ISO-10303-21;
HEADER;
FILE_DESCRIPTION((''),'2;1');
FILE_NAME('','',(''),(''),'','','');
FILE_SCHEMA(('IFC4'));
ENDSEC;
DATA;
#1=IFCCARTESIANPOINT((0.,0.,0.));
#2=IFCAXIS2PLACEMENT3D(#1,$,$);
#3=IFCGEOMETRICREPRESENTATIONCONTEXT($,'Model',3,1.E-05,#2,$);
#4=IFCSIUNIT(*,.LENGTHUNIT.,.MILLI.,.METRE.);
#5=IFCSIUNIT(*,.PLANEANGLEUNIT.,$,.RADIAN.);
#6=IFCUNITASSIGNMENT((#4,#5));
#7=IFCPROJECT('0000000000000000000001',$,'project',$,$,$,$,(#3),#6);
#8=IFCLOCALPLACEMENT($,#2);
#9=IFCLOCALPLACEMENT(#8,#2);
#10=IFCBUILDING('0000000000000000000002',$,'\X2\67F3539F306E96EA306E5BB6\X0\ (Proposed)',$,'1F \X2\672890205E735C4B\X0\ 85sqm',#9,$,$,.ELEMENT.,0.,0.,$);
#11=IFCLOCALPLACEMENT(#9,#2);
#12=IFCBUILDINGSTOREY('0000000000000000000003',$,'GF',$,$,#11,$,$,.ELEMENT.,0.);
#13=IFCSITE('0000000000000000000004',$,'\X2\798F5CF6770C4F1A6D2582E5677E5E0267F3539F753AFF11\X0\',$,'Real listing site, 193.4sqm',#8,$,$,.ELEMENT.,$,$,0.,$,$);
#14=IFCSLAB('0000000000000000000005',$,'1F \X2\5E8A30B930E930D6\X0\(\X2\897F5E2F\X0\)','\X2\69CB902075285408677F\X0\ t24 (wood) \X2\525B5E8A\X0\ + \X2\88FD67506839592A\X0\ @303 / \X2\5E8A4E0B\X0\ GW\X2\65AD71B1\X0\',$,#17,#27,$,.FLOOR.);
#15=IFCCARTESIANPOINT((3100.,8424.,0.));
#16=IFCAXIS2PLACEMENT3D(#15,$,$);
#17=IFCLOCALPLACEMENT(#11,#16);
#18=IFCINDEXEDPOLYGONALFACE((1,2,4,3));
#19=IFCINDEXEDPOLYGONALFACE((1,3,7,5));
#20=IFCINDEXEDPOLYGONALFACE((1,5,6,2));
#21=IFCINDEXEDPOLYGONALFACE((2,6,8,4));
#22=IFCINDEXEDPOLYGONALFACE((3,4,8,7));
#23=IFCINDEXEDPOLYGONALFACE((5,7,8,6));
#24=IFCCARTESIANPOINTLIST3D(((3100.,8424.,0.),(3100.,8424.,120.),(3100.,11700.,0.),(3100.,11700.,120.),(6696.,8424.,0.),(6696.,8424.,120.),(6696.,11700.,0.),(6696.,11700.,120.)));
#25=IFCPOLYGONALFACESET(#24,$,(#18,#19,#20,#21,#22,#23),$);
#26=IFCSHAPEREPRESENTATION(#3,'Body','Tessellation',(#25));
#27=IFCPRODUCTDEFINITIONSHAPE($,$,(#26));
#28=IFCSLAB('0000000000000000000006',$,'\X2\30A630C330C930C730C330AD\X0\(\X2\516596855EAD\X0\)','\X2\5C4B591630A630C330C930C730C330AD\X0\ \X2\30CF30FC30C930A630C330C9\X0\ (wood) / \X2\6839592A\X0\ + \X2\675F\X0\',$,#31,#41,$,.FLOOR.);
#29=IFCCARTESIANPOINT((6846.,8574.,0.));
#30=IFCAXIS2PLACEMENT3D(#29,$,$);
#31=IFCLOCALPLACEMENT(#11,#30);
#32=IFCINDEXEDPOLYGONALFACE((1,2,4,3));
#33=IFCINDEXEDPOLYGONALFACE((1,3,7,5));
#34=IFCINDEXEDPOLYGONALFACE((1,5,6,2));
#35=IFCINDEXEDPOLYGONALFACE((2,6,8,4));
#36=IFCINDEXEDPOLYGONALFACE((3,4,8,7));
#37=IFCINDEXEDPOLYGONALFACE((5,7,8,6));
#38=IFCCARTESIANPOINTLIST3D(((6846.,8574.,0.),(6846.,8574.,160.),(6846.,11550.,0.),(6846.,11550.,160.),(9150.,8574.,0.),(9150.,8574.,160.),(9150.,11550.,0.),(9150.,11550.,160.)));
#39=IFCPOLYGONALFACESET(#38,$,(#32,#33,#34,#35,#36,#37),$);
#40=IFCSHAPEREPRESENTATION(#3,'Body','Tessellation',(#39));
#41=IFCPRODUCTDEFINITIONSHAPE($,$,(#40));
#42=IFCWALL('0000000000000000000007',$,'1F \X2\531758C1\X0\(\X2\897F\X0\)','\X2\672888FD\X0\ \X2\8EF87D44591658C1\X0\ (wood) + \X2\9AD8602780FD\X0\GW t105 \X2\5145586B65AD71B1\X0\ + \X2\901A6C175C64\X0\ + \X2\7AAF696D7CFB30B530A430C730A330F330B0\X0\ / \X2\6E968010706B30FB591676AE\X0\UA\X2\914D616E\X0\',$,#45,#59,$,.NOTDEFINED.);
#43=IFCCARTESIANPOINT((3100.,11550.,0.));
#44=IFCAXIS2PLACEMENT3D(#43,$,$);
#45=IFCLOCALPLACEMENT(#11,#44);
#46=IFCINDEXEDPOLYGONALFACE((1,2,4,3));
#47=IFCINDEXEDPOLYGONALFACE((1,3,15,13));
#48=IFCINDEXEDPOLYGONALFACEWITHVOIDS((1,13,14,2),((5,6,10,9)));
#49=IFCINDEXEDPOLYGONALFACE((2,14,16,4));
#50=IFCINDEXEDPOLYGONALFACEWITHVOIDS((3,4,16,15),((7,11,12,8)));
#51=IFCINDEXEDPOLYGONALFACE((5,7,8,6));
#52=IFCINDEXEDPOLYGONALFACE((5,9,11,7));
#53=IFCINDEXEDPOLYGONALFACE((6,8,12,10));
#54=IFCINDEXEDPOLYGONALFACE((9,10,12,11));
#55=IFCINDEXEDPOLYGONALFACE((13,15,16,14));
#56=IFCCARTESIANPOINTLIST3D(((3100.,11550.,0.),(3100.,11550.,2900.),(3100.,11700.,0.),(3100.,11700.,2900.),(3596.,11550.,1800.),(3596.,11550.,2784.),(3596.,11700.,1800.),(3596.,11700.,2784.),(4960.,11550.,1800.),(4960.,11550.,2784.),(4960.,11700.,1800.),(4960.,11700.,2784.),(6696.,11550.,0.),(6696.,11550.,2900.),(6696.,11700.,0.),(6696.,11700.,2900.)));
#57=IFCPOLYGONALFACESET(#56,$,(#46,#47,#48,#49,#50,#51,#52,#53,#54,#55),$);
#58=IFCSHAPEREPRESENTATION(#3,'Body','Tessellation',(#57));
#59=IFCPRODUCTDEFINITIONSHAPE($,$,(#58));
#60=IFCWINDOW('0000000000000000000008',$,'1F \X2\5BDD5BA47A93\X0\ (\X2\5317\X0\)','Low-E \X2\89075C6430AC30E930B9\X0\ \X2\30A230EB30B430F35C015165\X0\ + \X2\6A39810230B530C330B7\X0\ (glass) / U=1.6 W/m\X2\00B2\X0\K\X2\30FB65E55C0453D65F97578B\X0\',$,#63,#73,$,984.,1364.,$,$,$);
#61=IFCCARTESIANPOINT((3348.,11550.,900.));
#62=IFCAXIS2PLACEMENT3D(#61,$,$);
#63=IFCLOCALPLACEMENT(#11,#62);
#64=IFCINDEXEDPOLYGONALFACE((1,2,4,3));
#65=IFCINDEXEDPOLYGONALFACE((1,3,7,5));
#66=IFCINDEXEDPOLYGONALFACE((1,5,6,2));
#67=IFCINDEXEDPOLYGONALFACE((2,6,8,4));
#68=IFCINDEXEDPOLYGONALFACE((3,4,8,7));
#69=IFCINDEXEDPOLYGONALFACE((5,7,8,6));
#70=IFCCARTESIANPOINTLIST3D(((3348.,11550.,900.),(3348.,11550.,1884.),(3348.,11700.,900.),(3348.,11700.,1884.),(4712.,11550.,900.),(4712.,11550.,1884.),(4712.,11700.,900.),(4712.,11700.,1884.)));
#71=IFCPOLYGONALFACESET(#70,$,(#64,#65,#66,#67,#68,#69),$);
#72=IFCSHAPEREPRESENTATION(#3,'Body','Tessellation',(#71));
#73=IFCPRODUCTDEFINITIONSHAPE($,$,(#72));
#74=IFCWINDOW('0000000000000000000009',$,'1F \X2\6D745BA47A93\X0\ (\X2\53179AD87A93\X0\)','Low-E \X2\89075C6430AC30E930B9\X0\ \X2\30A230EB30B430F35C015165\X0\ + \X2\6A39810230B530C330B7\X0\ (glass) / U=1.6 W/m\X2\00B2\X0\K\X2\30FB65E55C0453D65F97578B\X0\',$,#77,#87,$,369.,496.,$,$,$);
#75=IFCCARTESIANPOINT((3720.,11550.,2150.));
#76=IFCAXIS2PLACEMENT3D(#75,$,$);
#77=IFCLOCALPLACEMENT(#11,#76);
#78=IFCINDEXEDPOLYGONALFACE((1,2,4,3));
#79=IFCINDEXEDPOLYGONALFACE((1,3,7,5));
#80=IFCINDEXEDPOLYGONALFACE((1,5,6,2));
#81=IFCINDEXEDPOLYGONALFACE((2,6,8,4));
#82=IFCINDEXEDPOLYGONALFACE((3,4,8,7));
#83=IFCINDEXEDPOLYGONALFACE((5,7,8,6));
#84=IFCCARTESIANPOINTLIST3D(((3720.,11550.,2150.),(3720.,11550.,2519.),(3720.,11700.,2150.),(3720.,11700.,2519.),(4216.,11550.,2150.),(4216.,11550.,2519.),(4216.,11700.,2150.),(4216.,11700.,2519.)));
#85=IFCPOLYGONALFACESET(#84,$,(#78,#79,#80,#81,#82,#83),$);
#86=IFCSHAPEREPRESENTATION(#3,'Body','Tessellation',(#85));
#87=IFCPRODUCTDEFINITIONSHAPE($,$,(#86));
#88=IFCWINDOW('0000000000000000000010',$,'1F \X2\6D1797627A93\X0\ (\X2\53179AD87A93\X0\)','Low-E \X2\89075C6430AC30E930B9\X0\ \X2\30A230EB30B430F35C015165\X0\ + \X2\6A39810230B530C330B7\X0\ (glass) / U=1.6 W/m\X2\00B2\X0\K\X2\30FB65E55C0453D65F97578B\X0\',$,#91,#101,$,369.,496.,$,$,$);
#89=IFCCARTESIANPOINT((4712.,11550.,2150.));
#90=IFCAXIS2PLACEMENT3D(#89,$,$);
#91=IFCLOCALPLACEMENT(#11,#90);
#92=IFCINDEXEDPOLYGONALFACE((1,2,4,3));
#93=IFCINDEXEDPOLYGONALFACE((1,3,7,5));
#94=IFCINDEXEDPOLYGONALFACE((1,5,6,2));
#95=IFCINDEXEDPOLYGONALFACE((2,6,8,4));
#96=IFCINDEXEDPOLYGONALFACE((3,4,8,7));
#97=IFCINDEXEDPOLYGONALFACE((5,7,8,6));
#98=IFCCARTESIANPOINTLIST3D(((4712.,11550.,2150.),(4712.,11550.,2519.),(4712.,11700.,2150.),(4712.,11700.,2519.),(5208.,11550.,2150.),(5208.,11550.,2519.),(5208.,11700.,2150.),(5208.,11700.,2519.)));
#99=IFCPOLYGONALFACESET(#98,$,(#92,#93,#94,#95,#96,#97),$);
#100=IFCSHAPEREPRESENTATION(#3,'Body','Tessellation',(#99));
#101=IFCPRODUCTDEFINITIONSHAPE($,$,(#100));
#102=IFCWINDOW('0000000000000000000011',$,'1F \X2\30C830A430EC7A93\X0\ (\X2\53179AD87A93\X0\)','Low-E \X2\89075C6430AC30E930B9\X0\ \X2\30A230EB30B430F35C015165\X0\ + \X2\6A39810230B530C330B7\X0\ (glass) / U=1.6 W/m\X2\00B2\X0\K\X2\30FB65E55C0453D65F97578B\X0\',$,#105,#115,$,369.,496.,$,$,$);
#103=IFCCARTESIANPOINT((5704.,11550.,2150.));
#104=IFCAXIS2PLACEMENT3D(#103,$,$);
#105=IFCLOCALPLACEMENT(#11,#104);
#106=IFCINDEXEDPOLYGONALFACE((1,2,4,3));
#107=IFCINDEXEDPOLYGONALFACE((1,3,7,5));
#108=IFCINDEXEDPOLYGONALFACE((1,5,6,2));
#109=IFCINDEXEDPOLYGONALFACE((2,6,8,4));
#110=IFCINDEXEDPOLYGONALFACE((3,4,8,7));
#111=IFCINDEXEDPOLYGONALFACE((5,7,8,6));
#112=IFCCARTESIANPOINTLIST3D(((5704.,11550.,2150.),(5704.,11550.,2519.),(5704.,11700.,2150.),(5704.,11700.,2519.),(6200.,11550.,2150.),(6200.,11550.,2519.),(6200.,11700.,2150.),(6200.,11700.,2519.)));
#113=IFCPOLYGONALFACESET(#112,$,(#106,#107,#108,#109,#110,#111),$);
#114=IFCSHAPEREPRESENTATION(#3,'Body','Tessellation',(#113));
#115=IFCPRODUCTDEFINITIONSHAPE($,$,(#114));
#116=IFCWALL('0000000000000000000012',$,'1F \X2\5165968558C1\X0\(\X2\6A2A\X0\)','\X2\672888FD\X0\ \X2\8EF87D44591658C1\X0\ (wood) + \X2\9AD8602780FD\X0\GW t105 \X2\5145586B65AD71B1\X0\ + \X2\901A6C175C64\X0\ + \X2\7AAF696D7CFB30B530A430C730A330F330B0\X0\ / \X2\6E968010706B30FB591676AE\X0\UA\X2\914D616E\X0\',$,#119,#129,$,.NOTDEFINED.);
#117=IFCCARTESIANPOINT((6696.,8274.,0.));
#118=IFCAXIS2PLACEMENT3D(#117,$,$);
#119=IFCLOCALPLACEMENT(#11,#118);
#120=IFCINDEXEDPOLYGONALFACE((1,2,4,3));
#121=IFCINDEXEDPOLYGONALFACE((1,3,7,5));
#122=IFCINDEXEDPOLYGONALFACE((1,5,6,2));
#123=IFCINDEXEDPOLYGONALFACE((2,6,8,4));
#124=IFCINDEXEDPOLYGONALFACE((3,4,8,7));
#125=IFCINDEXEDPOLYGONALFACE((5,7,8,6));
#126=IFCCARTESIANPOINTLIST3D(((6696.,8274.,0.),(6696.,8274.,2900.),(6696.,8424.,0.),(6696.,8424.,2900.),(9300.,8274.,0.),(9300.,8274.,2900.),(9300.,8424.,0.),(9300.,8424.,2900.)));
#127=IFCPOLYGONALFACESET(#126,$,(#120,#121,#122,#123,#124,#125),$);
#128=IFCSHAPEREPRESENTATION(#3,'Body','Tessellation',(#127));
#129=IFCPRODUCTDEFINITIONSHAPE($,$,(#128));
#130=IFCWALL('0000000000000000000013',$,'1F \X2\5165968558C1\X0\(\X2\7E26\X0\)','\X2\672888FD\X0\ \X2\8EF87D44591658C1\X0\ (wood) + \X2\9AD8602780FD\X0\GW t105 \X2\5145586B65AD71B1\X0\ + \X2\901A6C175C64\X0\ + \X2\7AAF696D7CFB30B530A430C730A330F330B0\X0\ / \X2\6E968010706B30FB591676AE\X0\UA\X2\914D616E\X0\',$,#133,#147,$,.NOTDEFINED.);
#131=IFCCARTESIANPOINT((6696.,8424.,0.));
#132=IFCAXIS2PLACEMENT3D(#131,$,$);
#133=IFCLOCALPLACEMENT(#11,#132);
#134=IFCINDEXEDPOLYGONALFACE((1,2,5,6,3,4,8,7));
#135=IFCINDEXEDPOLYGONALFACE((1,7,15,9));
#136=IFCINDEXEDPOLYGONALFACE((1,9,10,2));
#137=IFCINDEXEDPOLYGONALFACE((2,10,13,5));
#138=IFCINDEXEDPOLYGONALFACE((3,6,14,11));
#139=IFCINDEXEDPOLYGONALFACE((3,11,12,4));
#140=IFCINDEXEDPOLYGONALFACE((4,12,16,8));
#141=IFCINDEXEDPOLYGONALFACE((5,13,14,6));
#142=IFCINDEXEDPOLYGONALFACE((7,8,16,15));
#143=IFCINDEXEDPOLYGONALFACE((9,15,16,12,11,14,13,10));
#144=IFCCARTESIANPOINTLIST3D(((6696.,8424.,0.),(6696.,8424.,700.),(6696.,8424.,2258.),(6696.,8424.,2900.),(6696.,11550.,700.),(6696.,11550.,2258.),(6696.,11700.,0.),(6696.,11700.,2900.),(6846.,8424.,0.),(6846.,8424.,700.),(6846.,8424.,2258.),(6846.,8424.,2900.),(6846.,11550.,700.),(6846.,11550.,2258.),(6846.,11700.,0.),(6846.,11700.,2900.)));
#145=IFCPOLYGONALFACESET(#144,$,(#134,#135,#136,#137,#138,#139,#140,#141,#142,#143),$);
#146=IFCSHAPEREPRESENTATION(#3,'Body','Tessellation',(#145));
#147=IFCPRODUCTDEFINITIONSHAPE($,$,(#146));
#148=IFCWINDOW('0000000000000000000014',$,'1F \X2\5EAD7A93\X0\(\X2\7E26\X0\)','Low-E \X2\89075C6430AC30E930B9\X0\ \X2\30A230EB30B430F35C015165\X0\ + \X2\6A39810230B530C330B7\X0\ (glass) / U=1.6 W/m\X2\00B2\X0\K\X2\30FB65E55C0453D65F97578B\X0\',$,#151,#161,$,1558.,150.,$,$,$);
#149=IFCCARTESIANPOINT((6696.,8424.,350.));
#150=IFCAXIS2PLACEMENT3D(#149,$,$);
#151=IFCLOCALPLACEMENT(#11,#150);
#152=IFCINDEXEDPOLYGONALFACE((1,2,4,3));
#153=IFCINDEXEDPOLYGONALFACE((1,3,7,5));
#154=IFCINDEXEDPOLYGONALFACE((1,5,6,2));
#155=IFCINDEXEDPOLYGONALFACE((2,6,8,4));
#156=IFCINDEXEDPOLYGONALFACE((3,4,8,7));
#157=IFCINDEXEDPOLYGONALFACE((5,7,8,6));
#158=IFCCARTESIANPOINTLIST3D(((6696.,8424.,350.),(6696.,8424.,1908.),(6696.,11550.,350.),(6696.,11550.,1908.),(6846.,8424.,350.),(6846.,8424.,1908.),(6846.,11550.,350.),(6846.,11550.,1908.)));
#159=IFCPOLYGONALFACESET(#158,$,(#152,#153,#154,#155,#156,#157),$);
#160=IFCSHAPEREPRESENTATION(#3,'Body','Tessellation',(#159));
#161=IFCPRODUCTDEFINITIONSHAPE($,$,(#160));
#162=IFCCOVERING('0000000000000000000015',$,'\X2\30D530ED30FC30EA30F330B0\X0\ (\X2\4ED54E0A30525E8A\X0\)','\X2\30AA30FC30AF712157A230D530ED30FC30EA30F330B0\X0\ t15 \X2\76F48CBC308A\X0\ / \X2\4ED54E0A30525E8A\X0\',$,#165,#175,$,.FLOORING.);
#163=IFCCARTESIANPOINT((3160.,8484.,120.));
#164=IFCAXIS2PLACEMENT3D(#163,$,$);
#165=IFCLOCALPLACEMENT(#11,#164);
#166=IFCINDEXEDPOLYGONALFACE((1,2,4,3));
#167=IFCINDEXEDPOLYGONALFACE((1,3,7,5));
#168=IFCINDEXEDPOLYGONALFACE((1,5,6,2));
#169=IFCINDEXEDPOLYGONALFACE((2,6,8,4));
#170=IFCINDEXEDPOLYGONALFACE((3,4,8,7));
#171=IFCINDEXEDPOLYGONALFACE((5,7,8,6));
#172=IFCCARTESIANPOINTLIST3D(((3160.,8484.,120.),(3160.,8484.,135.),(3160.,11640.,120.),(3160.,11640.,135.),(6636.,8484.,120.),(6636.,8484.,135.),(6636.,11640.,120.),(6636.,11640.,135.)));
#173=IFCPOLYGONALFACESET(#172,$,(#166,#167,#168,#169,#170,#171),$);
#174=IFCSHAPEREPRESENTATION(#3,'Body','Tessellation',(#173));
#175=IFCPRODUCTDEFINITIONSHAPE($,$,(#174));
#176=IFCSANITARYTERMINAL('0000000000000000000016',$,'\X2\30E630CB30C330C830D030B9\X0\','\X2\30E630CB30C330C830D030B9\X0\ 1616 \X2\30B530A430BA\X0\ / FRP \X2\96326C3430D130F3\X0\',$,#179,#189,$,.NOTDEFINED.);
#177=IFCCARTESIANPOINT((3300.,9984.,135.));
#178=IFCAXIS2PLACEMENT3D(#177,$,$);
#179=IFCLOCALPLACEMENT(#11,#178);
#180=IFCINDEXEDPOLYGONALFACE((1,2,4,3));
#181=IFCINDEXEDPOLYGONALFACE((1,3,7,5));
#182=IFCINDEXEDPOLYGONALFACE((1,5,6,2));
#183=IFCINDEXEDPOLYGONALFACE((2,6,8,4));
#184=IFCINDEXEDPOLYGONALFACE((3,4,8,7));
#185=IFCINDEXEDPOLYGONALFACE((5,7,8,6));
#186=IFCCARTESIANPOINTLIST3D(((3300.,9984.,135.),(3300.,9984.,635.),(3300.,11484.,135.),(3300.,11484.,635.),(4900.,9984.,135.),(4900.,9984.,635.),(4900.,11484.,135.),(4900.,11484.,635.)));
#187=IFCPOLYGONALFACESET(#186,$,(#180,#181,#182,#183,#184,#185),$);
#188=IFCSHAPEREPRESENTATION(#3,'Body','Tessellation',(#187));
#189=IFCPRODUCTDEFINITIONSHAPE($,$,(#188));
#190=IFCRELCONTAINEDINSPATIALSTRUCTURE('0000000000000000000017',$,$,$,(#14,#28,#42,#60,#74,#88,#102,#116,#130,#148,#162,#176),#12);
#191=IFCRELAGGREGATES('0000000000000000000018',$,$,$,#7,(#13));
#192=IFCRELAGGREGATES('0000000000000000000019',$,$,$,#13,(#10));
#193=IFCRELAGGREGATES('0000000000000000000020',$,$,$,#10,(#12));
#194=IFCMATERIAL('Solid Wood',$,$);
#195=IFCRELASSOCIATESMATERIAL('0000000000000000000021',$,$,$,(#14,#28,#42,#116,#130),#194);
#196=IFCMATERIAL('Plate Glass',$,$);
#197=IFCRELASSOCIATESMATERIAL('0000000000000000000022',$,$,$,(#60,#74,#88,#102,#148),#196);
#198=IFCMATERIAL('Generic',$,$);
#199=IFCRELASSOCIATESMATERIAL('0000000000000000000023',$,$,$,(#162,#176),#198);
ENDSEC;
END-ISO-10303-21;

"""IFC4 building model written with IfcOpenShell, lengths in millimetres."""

from ifc_helpers import new_model, si_unit, frame, frame_2d, origin, place, context, project, spatial, rectangle, extrude, material, element, fill, save


model = new_model("IFC4")

# Units and contexts
model_context = context("Model", 3, precision=1e-05, world=origin())
ifc_project = project(units=[si_unit("LENGTHUNIT", "METRE", prefix="MILLI"), si_unit("PLANEANGLEUNIT", "RADIAN")], contexts=[model_context])

# Site, building, storey
site_placement = place(None, origin())
site = spatial("IfcSite", under=ifc_project, at=site_placement, Name="福島県会津若松市柳原町１", ObjectType="Real listing site, 193.4sqm", CompositionType="ELEMENT", RefElevation=0.0)
building_placement = place(site_placement, origin())
building = spatial("IfcBuilding", under=site, at=building_placement, Name="柳原の雪の家 (Proposed)", ObjectType="1F 木造平屋 85sqm", CompositionType="ELEMENT", ElevationOfRefHeight=0.0, ElevationOfTerrain=0.0)
storey_placement = place(building_placement, origin())
storey = spatial("IfcBuildingStorey", under=building, at=storey_placement, Name="GF", CompositionType="ELEMENT", Elevation=0.0)

# Slabs
ifc_material_1 = material(Name="Solid Wood")
slab_1_placement = place(storey_placement, frame((3100.0, 8424.0, 0.0)))
element("IfcSlab", 1, at=slab_1_placement, inside=storey, material=ifc_material_1, Name="1F 床スラブ(西帯)", Description="構造用合板 t24 (wood) 剛床 + 製材根太 @303 / 床下 GW断熱", PredefinedType="FLOOR", context=model_context, shape_type="SweptSolid", body=[
    extrude(rectangle(XDim=3596.0, YDim=3276.0, at=frame_2d((1798.0, 1638.0))), frame((3100.0, 8424.0, 0.0)), (0.0, 0.0, 1.0), 120.0),
])
slab_2_placement = place(storey_placement, frame((6846.0, 8574.0, 0.0)))
element("IfcSlab", 2, at=slab_2_placement, inside=storey, material=ifc_material_1, Name="ウッドデッキ(入隅庭)", Description="屋外ウッドデッキ ハードウッド (wood) / 根太 + 束", PredefinedType="FLOOR", context=model_context, shape_type="SweptSolid", body=[
    extrude(rectangle(XDim=2304.0, YDim=2976.0, at=frame_2d((1152.0, 1488.0))), frame((6846.0, 8574.0, 0.0)), (0.0, 0.0, 1.0), 160.0),
])

# Wall, openings, windows
wall_1_placement = place(storey_placement, frame((3100.0, 11550.0, 0.0)))
wall_1 = element("IfcWall", 3, at=wall_1_placement, inside=storey, material=ifc_material_1, Name="1F 北壁(西)", Description="木製 軸組外壁 (wood) + 高性能GW t105 充填断熱 + 通気層 + 窯業系サイディング / 準耐火・外皮UA配慮", PredefinedType="NOTDEFINED", context=model_context, shape_type="SweptSolid", body=[
    extrude(rectangle(XDim=3596.0, YDim=150.0, at=frame_2d((1798.0, 75.0))), frame((3100.0, 11550.0, 0.0)), (0.0, 0.0, 1.0), 2900.0),
])
opening_1_placement = place(storey_placement, frame((3348.0, 11550.0, 900.0)))
opening_1 = element("IfcOpeningElement", 4, at=opening_1_placement, cuts=wall_1, PredefinedType="NOTDEFINED", context=model_context, shape_type="SweptSolid", body=[
    extrude(rectangle(XDim=1364.0, YDim=150.0, at=frame_2d((682.0, 75.0))), frame((3348.0, 11550.0, 900.0)), (0.0, 0.0, 1.0), 984.0),
])
opening_2_placement = place(storey_placement, frame((3720.0, 11550.0, 2150.0)))
opening_2 = element("IfcOpeningElement", 5, at=opening_2_placement, cuts=wall_1, PredefinedType="NOTDEFINED", context=model_context, shape_type="SweptSolid", body=[
    extrude(rectangle(XDim=496.0, YDim=150.0, at=frame_2d((248.0, 75.0))), frame((3720.0, 11550.0, 2150.0)), (0.0, 0.0, 1.0), 369.0),
])
opening_3_placement = place(storey_placement, frame((4712.0, 11550.0, 2150.0)))
opening_3 = element("IfcOpeningElement", 6, at=opening_3_placement, cuts=wall_1, PredefinedType="NOTDEFINED", context=model_context, shape_type="SweptSolid", body=[
    extrude(rectangle(XDim=496.0, YDim=150.0, at=frame_2d((248.0, 75.0))), frame((4712.0, 11550.0, 2150.0)), (0.0, 0.0, 1.0), 369.0),
])
opening_4_placement = place(storey_placement, frame((5704.0, 11550.0, 2150.0)))
opening_4 = element("IfcOpeningElement", 7, at=opening_4_placement, cuts=wall_1, PredefinedType="NOTDEFINED", context=model_context, shape_type="SweptSolid", body=[
    extrude(rectangle(XDim=496.0, YDim=150.0, at=frame_2d((248.0, 75.0))), frame((5704.0, 11550.0, 2150.0)), (0.0, 0.0, 1.0), 369.0),
])
ifc_material_2 = material(Name="Plate Glass")
window_1_placement = place(storey_placement, frame((3348.0, 11550.0, 900.0)))
window_1 = element("IfcWindow", 8, at=window_1_placement, inside=storey, material=ifc_material_2, Name="1F 寝室窓 (北)", Description="Low-E 複層ガラス アルゴン封入 + 樹脂サッシ (glass) / U=1.6 W/m²K・日射取得型", OverallHeight=984.0, OverallWidth=1364.0, context=model_context, shape_type="SweptSolid", body=[
    extrude(rectangle(XDim=1364.0, YDim=150.0, at=frame_2d((682.0, 75.0))), frame((3348.0, 11550.0, 900.0)), (0.0, 0.0, 1.0), 984.0),
])
fill(opening_1, window_1)
window_2_placement = place(storey_placement, frame((3720.0, 11550.0, 2150.0)))
window_2 = element("IfcWindow", 9, at=window_2_placement, inside=storey, material=ifc_material_2, Name="1F 浴室窓 (北高窓)", Description="Low-E 複層ガラス アルゴン封入 + 樹脂サッシ (glass) / U=1.6 W/m²K・日射取得型", OverallHeight=369.0, OverallWidth=496.0, context=model_context, shape_type="SweptSolid", body=[
    extrude(rectangle(XDim=496.0, YDim=150.0, at=frame_2d((248.0, 75.0))), frame((3720.0, 11550.0, 2150.0)), (0.0, 0.0, 1.0), 369.0),
])
fill(opening_2, window_2)
window_3_placement = place(storey_placement, frame((4712.0, 11550.0, 2150.0)))
window_3 = element("IfcWindow", 10, at=window_3_placement, inside=storey, material=ifc_material_2, Name="1F 洗面窓 (北高窓)", Description="Low-E 複層ガラス アルゴン封入 + 樹脂サッシ (glass) / U=1.6 W/m²K・日射取得型", OverallHeight=369.0, OverallWidth=496.0, context=model_context, shape_type="SweptSolid", body=[
    extrude(rectangle(XDim=496.0, YDim=150.0, at=frame_2d((248.0, 75.0))), frame((4712.0, 11550.0, 2150.0)), (0.0, 0.0, 1.0), 369.0),
])
fill(opening_3, window_3)
window_4_placement = place(storey_placement, frame((5704.0, 11550.0, 2150.0)))
window_4 = element("IfcWindow", 11, at=window_4_placement, inside=storey, material=ifc_material_2, Name="1F トイレ窓 (北高窓)", Description="Low-E 複層ガラス アルゴン封入 + 樹脂サッシ (glass) / U=1.6 W/m²K・日射取得型", OverallHeight=369.0, OverallWidth=496.0, context=model_context, shape_type="SweptSolid", body=[
    extrude(rectangle(XDim=496.0, YDim=150.0, at=frame_2d((248.0, 75.0))), frame((5704.0, 11550.0, 2150.0)), (0.0, 0.0, 1.0), 369.0),
])
fill(opening_4, window_4)

# Wall
wall_2_placement = place(storey_placement, frame((6696.0, 8274.0, 0.0)))
element("IfcWall", 12, at=wall_2_placement, inside=storey, material=ifc_material_1, Name="1F 入隅壁(横)", Description="木製 軸組外壁 (wood) + 高性能GW t105 充填断熱 + 通気層 + 窯業系サイディング / 準耐火・外皮UA配慮", PredefinedType="NOTDEFINED", context=model_context, shape_type="SweptSolid", body=[
    extrude(rectangle(XDim=2604.0, YDim=150.0, at=frame_2d((1302.0, 75.0))), frame((6696.0, 8274.0, 0.0)), (0.0, 0.0, 1.0), 2900.0),
])

# Wall, opening, window
wall_3_placement = place(storey_placement, frame((6696.0, 8424.0, 0.0)))
wall_3 = element("IfcWall", 13, at=wall_3_placement, inside=storey, material=ifc_material_1, Name="1F 入隅壁(縦)", Description="木製 軸組外壁 (wood) + 高性能GW t105 充填断熱 + 通気層 + 窯業系サイディング / 準耐火・外皮UA配慮", PredefinedType="NOTDEFINED", context=model_context, shape_type="SweptSolid", body=[
    extrude(rectangle(XDim=150.0, YDim=3276.0, at=frame_2d((75.0, 1638.0))), frame((6696.0, 8424.0, 0.0)), (0.0, 0.0, 1.0), 2900.0),
])
opening_5_placement = place(storey_placement, frame((6696.0, 8424.0, 350.0)))
opening_5 = element("IfcOpeningElement", 14, at=opening_5_placement, cuts=wall_3, PredefinedType="NOTDEFINED", context=model_context, shape_type="SweptSolid", body=[
    extrude(rectangle(XDim=150.0, YDim=3126.0, at=frame_2d((75.0, 1563.0))), frame((6696.0, 8424.0, 350.0)), (0.0, 0.0, 1.0), 1558.0),
])
window_5_placement = place(storey_placement, frame((6696.0, 8424.0, 350.0)))
window_5 = element("IfcWindow", 15, at=window_5_placement, inside=storey, material=ifc_material_2, Name="1F 庭窓(縦)", Description="Low-E 複層ガラス アルゴン封入 + 樹脂サッシ (glass) / U=1.6 W/m²K・日射取得型", OverallHeight=1558.0, OverallWidth=150.0, context=model_context, shape_type="SweptSolid", body=[
    extrude(rectangle(XDim=150.0, YDim=3126.0, at=frame_2d((75.0, 1563.0))), frame((6696.0, 8424.0, 350.0)), (0.0, 0.0, 1.0), 1558.0),
])
fill(opening_5, window_5)

# Covering
ifc_material_3 = material(Name="Generic")
covering_placement = place(storey_placement, frame((3160.0, 8484.0, 120.0)))
element("IfcCovering", 16, at=covering_placement, inside=storey, material=ifc_material_3, Name="フローリング (仕上げ床)", Description="オーク無垢フローリング t15 直貼り / 仕上げ床", PredefinedType="FLOORING", context=model_context, shape_type="SweptSolid", body=[
    extrude(rectangle(XDim=3476.0, YDim=3156.0, at=frame_2d((1738.0, 1578.0))), frame((3160.0, 8484.0, 120.0)), (0.0, 0.0, 1.0), 15.0),
])

# Sanitary terminal
sanitary_terminal_1_placement = place(storey_placement, frame((3300.0, 9984.0, 135.0)))
element("IfcSanitaryTerminal", 17, at=sanitary_terminal_1_placement, inside=storey, material=ifc_material_3, Name="ユニットバス", Description="ユニットバス 1616 サイズ / FRP 防水パン", PredefinedType="NOTDEFINED", context=model_context, shape_type="SweptSolid", body=[
    extrude(rectangle(XDim=1600.0, YDim=1500.0, at=frame_2d((800.0, 750.0))), frame((3300.0, 9984.0, 135.0)), (0.0, 0.0, 1.0), 500.0),
])

save(model, "model.ifc")
